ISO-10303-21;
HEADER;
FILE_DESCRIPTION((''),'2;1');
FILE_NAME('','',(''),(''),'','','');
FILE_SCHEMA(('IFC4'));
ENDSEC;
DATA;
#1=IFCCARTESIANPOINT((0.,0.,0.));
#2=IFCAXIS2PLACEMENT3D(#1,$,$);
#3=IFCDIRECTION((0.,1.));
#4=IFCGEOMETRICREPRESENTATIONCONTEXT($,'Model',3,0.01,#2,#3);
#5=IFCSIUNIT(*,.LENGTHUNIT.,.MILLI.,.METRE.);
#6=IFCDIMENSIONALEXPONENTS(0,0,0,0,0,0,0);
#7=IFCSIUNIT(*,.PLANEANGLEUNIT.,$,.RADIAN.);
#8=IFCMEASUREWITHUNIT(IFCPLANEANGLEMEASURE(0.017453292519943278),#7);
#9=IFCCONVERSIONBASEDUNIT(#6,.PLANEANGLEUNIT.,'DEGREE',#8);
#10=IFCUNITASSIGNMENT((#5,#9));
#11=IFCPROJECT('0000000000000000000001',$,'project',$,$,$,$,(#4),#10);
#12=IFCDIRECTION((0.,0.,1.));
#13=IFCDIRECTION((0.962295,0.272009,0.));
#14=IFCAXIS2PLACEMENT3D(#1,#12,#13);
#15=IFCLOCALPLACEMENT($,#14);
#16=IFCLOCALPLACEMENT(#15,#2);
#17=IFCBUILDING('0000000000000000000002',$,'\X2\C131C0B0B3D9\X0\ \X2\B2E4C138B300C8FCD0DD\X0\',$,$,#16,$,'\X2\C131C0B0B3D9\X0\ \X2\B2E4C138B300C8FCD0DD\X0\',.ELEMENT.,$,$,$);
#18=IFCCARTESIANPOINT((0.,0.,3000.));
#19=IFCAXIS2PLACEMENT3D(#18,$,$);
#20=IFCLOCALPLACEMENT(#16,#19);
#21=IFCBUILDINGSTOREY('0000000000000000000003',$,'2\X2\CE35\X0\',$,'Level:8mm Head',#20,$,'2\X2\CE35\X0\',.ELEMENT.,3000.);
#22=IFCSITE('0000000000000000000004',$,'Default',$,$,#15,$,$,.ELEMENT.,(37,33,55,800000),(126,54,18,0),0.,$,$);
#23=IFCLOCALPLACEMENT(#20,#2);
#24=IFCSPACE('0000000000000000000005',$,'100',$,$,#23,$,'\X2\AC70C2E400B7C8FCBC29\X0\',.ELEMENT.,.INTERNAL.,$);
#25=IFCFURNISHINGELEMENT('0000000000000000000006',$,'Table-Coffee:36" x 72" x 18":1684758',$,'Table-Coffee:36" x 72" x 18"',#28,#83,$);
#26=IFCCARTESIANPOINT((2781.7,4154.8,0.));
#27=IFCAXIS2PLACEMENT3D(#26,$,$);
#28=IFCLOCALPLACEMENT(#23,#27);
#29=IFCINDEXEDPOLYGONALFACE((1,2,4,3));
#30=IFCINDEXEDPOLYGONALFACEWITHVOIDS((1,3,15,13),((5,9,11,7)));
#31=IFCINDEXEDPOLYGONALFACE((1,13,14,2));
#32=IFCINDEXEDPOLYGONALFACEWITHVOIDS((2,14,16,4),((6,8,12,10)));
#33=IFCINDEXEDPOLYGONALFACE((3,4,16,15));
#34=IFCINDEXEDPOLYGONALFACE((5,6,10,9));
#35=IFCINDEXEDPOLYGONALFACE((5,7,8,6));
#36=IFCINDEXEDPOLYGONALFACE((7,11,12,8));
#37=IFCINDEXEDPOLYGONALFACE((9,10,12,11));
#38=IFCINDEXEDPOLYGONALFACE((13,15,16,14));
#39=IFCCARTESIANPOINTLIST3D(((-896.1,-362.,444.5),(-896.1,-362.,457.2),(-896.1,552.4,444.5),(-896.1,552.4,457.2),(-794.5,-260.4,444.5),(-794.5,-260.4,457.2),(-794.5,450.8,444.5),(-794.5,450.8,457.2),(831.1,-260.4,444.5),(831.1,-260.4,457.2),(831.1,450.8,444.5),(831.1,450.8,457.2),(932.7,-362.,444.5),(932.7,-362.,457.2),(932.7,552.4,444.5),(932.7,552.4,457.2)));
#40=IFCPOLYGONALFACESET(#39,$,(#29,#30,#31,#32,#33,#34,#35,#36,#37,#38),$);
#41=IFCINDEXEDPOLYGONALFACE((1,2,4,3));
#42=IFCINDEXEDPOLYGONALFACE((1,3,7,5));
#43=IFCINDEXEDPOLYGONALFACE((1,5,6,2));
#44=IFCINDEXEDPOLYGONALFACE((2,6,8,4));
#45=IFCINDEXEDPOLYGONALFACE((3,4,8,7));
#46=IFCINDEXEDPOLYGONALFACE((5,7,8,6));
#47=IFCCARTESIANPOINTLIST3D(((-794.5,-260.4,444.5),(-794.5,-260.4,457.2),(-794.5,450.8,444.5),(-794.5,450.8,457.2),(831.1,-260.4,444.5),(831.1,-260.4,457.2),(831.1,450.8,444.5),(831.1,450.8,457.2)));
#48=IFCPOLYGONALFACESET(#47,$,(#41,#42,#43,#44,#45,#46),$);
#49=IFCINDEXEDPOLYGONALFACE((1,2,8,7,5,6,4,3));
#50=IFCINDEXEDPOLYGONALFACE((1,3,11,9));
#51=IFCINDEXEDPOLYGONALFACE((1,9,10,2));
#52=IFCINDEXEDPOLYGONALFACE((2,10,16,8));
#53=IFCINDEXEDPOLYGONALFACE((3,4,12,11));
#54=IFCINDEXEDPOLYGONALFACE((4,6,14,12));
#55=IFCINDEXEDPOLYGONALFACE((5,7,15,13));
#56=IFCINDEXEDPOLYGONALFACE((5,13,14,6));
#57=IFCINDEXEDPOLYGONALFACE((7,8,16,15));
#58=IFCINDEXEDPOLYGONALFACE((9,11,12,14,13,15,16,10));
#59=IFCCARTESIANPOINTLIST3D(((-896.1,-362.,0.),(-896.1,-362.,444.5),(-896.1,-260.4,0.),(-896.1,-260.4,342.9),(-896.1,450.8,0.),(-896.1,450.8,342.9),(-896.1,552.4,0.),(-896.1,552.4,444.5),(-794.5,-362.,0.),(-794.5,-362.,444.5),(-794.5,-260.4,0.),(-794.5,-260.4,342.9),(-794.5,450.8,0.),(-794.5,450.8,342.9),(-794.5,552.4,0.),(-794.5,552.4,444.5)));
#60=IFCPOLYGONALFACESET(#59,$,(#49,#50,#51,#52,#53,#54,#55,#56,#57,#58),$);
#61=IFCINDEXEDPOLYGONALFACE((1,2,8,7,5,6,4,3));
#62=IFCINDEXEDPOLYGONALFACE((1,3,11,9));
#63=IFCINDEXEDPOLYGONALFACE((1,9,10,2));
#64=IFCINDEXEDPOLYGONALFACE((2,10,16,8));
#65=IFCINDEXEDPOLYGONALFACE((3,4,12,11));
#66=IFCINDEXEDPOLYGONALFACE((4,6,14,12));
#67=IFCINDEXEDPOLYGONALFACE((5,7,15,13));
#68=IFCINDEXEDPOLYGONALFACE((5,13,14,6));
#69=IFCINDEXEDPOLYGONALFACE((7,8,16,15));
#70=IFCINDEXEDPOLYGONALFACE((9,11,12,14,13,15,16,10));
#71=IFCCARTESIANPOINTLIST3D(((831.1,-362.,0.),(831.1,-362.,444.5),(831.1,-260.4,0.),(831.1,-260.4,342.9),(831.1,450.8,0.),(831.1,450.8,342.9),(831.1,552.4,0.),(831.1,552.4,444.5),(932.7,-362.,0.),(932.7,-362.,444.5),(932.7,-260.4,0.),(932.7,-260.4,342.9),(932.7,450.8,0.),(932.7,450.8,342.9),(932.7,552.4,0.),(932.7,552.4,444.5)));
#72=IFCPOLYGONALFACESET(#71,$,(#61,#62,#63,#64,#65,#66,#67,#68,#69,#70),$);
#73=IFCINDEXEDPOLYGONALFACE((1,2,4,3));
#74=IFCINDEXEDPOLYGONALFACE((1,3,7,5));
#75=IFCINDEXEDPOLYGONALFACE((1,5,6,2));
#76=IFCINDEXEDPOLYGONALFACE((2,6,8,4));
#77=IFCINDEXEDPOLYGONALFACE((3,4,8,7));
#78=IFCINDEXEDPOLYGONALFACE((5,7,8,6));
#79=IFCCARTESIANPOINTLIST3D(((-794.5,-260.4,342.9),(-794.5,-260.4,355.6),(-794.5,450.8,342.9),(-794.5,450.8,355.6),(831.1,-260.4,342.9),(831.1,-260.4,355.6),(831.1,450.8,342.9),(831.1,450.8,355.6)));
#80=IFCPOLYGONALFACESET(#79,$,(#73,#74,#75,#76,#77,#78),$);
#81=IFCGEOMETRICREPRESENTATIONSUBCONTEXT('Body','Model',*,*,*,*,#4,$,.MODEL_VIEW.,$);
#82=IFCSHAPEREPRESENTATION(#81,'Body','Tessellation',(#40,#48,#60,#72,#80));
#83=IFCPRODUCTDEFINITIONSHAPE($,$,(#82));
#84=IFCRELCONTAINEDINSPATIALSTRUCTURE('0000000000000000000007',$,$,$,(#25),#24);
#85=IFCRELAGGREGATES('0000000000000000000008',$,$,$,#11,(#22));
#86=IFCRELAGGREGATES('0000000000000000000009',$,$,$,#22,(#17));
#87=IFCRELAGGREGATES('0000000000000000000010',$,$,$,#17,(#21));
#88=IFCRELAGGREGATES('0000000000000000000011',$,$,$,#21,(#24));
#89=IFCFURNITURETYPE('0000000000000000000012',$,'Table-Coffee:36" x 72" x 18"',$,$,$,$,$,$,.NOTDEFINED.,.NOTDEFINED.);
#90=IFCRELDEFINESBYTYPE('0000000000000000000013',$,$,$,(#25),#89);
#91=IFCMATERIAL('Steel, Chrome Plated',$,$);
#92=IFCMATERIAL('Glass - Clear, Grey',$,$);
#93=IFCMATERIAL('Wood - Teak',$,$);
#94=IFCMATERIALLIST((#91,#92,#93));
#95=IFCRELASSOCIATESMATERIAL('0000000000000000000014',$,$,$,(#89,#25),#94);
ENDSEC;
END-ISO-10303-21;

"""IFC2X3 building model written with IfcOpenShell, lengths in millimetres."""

from ifc_helpers import new_model, entity, si_unit, converted_unit, direction, frame, origin, origin_2d_with_axis, place, context, subcontext, project, spatial, polyline, rectangle, outline, extrude, source, transform, mapped, material, material_list, type_object, type_shapes, element, save


model = new_model("IFC2X3")

# Units and contexts
model_context = context("Model", 3, precision=0.01, world=origin(), true_north=direction((0.0, 1.0)))
body_context = subcontext(model_context, "Body", "Model", "MODEL_VIEW")
ifc_project = project(units=[si_unit("LENGTHUNIT", "METRE", prefix="MILLI"), converted_unit("PLANEANGLEUNIT", "DEGREE", entity("IfcPlaneAngleMeasure", 0.017453292519943278), si_unit("PLANEANGLEUNIT", "RADIAN"), dimensions=[0, 0, 0, 0, 0, 0, 0])], contexts=[model_context])

# Site, building, storey
site_placement = place(None, frame((0.0, 0.0, 0.0), z_axis=(0.0, 0.0, 1.0), x_axis=(0.962295, 0.272009, 0.0)))
site = spatial("IfcSite", under=ifc_project, at=site_placement, Name="Default", CompositionType="ELEMENT", RefLatitude=(37, 33, 55, 800000), RefLongitude=(126, 54, 18, 0), RefElevation=0.0)
building_placement = place(site_placement, origin())
building = spatial("IfcBuilding", under=site, at=building_placement, Name="성산동 다세대주택", LongName="성산동 다세대주택", CompositionType="ELEMENT")
storey_placement = place(building_placement, frame((0.0, 0.0, 3000.0)))
storey = spatial("IfcBuildingStorey", under=building, at=storey_placement, Name="2층", ObjectType="Level:8mm Head", LongName="2층", CompositionType="ELEMENT", Elevation=3000.0)

# Shared definitions
space_1_placement = place(storey_placement, origin())
space_1 = spatial("IfcSpace", under=storey, at=space_1_placement, Name="100", LongName="거실·주방", CompositionType="ELEMENT", InteriorOrExteriorSpace="INTERNAL")

# Furnishing element
ifc_material_1 = material(Name="Steel, Chrome Plated")
ifc_material_2 = material(Name="Glass - Clear, Grey")
ifc_material_3 = material(Name="Wood - Teak")
ifc_material_list_1 = material_list([ifc_material_1, ifc_material_2, ifc_material_3])
furniture_type_1 = type_object("IfcFurnitureType", Name="Table-Coffee:36\" x 72\" x 18\"", AssemblyPlace="NOTDEFINED", material=ifc_material_list_1)
shared_shape_1 = source(origin(), body_context, "Body", "SweptSolid", [
    extrude(outline(polyline([(-914.4, -457.2), (914.4, -457.2), (914.4, 457.2), (-914.4, 457.2), (-914.4, -457.2)]), holes=[polyline([(-812.8, -355.6), (-812.8, 355.6), (812.8, 355.6), (812.8, -355.6), (-812.8, -355.6)])]), frame((18.3, 95.2, 444.5), z_axis=(0.0, 0.0, 1.0), x_axis=(-1.0, 0.0, 0.0)), (0.0, 0.0, 1.0), 12.7),
    extrude(rectangle(XDim=1625.6, YDim=711.2, at=origin_2d_with_axis()), frame((18.3, 95.2, 444.5), z_axis=(0.0, 0.0, 1.0), x_axis=(-1.0, 0.0, 0.0)), (0.0, 0.0, 1.0), 12.7),
    extrude(outline(polyline([(-457.2, -247.7), (457.2, -247.7), (457.2, 196.9), (355.6, 196.9), (355.6, -146.0), (-355.6, -146.0), (-355.6, 196.9), (-457.2, 196.9), (-457.2, -247.7)])), frame((-896.1, 95.2, 196.9), z_axis=(1.0, 0.0, 0.0), x_axis=(0.0, -1.0, 0.0)), (0.0, 0.0, 1.0), 101.6),
    extrude(outline(polyline([(-196.8, -457.2), (247.6, -457.2), (247.6, 457.2), (-196.8, 457.2), (-196.8, 355.6), (146.1, 355.6), (146.1, -355.6), (-196.8, -355.6), (-196.8, -457.2)])), frame((831.1, 95.2, 196.8), z_axis=(1.0, 0.0, 0.0), x_axis=(0.0, 0.0, 1.0)), (0.0, 0.0, 1.0), 101.6),
    extrude(rectangle(XDim=1625.6, YDim=711.2, at=origin_2d_with_axis()), frame((18.3, 95.2, 342.9), z_axis=(0.0, 0.0, 1.0), x_axis=(-1.0, 0.0, 0.0)), (0.0, 0.0, 1.0), 12.7),
])
type_shapes(furniture_type_1, [shared_shape_1])
furnishing_1_placement = place(space_1_placement, frame((2781.7, 4154.8, 0.0)))
element("IfcFurnishingElement", 1, at=furnishing_1_placement, inside=space_1, type_object=furniture_type_1, material=ifc_material_list_1, Name="Table-Coffee:36\" x 72\" x 18\":1684758", ObjectType="Table-Coffee:36\" x 72\" x 18\"", context=body_context, shape_type="MappedRepresentation", body=[
    mapped(shared_shape_1, transform((0.0, 0.0, 0.0), scale=1.0)),
])

save(model, "model.ifc")
